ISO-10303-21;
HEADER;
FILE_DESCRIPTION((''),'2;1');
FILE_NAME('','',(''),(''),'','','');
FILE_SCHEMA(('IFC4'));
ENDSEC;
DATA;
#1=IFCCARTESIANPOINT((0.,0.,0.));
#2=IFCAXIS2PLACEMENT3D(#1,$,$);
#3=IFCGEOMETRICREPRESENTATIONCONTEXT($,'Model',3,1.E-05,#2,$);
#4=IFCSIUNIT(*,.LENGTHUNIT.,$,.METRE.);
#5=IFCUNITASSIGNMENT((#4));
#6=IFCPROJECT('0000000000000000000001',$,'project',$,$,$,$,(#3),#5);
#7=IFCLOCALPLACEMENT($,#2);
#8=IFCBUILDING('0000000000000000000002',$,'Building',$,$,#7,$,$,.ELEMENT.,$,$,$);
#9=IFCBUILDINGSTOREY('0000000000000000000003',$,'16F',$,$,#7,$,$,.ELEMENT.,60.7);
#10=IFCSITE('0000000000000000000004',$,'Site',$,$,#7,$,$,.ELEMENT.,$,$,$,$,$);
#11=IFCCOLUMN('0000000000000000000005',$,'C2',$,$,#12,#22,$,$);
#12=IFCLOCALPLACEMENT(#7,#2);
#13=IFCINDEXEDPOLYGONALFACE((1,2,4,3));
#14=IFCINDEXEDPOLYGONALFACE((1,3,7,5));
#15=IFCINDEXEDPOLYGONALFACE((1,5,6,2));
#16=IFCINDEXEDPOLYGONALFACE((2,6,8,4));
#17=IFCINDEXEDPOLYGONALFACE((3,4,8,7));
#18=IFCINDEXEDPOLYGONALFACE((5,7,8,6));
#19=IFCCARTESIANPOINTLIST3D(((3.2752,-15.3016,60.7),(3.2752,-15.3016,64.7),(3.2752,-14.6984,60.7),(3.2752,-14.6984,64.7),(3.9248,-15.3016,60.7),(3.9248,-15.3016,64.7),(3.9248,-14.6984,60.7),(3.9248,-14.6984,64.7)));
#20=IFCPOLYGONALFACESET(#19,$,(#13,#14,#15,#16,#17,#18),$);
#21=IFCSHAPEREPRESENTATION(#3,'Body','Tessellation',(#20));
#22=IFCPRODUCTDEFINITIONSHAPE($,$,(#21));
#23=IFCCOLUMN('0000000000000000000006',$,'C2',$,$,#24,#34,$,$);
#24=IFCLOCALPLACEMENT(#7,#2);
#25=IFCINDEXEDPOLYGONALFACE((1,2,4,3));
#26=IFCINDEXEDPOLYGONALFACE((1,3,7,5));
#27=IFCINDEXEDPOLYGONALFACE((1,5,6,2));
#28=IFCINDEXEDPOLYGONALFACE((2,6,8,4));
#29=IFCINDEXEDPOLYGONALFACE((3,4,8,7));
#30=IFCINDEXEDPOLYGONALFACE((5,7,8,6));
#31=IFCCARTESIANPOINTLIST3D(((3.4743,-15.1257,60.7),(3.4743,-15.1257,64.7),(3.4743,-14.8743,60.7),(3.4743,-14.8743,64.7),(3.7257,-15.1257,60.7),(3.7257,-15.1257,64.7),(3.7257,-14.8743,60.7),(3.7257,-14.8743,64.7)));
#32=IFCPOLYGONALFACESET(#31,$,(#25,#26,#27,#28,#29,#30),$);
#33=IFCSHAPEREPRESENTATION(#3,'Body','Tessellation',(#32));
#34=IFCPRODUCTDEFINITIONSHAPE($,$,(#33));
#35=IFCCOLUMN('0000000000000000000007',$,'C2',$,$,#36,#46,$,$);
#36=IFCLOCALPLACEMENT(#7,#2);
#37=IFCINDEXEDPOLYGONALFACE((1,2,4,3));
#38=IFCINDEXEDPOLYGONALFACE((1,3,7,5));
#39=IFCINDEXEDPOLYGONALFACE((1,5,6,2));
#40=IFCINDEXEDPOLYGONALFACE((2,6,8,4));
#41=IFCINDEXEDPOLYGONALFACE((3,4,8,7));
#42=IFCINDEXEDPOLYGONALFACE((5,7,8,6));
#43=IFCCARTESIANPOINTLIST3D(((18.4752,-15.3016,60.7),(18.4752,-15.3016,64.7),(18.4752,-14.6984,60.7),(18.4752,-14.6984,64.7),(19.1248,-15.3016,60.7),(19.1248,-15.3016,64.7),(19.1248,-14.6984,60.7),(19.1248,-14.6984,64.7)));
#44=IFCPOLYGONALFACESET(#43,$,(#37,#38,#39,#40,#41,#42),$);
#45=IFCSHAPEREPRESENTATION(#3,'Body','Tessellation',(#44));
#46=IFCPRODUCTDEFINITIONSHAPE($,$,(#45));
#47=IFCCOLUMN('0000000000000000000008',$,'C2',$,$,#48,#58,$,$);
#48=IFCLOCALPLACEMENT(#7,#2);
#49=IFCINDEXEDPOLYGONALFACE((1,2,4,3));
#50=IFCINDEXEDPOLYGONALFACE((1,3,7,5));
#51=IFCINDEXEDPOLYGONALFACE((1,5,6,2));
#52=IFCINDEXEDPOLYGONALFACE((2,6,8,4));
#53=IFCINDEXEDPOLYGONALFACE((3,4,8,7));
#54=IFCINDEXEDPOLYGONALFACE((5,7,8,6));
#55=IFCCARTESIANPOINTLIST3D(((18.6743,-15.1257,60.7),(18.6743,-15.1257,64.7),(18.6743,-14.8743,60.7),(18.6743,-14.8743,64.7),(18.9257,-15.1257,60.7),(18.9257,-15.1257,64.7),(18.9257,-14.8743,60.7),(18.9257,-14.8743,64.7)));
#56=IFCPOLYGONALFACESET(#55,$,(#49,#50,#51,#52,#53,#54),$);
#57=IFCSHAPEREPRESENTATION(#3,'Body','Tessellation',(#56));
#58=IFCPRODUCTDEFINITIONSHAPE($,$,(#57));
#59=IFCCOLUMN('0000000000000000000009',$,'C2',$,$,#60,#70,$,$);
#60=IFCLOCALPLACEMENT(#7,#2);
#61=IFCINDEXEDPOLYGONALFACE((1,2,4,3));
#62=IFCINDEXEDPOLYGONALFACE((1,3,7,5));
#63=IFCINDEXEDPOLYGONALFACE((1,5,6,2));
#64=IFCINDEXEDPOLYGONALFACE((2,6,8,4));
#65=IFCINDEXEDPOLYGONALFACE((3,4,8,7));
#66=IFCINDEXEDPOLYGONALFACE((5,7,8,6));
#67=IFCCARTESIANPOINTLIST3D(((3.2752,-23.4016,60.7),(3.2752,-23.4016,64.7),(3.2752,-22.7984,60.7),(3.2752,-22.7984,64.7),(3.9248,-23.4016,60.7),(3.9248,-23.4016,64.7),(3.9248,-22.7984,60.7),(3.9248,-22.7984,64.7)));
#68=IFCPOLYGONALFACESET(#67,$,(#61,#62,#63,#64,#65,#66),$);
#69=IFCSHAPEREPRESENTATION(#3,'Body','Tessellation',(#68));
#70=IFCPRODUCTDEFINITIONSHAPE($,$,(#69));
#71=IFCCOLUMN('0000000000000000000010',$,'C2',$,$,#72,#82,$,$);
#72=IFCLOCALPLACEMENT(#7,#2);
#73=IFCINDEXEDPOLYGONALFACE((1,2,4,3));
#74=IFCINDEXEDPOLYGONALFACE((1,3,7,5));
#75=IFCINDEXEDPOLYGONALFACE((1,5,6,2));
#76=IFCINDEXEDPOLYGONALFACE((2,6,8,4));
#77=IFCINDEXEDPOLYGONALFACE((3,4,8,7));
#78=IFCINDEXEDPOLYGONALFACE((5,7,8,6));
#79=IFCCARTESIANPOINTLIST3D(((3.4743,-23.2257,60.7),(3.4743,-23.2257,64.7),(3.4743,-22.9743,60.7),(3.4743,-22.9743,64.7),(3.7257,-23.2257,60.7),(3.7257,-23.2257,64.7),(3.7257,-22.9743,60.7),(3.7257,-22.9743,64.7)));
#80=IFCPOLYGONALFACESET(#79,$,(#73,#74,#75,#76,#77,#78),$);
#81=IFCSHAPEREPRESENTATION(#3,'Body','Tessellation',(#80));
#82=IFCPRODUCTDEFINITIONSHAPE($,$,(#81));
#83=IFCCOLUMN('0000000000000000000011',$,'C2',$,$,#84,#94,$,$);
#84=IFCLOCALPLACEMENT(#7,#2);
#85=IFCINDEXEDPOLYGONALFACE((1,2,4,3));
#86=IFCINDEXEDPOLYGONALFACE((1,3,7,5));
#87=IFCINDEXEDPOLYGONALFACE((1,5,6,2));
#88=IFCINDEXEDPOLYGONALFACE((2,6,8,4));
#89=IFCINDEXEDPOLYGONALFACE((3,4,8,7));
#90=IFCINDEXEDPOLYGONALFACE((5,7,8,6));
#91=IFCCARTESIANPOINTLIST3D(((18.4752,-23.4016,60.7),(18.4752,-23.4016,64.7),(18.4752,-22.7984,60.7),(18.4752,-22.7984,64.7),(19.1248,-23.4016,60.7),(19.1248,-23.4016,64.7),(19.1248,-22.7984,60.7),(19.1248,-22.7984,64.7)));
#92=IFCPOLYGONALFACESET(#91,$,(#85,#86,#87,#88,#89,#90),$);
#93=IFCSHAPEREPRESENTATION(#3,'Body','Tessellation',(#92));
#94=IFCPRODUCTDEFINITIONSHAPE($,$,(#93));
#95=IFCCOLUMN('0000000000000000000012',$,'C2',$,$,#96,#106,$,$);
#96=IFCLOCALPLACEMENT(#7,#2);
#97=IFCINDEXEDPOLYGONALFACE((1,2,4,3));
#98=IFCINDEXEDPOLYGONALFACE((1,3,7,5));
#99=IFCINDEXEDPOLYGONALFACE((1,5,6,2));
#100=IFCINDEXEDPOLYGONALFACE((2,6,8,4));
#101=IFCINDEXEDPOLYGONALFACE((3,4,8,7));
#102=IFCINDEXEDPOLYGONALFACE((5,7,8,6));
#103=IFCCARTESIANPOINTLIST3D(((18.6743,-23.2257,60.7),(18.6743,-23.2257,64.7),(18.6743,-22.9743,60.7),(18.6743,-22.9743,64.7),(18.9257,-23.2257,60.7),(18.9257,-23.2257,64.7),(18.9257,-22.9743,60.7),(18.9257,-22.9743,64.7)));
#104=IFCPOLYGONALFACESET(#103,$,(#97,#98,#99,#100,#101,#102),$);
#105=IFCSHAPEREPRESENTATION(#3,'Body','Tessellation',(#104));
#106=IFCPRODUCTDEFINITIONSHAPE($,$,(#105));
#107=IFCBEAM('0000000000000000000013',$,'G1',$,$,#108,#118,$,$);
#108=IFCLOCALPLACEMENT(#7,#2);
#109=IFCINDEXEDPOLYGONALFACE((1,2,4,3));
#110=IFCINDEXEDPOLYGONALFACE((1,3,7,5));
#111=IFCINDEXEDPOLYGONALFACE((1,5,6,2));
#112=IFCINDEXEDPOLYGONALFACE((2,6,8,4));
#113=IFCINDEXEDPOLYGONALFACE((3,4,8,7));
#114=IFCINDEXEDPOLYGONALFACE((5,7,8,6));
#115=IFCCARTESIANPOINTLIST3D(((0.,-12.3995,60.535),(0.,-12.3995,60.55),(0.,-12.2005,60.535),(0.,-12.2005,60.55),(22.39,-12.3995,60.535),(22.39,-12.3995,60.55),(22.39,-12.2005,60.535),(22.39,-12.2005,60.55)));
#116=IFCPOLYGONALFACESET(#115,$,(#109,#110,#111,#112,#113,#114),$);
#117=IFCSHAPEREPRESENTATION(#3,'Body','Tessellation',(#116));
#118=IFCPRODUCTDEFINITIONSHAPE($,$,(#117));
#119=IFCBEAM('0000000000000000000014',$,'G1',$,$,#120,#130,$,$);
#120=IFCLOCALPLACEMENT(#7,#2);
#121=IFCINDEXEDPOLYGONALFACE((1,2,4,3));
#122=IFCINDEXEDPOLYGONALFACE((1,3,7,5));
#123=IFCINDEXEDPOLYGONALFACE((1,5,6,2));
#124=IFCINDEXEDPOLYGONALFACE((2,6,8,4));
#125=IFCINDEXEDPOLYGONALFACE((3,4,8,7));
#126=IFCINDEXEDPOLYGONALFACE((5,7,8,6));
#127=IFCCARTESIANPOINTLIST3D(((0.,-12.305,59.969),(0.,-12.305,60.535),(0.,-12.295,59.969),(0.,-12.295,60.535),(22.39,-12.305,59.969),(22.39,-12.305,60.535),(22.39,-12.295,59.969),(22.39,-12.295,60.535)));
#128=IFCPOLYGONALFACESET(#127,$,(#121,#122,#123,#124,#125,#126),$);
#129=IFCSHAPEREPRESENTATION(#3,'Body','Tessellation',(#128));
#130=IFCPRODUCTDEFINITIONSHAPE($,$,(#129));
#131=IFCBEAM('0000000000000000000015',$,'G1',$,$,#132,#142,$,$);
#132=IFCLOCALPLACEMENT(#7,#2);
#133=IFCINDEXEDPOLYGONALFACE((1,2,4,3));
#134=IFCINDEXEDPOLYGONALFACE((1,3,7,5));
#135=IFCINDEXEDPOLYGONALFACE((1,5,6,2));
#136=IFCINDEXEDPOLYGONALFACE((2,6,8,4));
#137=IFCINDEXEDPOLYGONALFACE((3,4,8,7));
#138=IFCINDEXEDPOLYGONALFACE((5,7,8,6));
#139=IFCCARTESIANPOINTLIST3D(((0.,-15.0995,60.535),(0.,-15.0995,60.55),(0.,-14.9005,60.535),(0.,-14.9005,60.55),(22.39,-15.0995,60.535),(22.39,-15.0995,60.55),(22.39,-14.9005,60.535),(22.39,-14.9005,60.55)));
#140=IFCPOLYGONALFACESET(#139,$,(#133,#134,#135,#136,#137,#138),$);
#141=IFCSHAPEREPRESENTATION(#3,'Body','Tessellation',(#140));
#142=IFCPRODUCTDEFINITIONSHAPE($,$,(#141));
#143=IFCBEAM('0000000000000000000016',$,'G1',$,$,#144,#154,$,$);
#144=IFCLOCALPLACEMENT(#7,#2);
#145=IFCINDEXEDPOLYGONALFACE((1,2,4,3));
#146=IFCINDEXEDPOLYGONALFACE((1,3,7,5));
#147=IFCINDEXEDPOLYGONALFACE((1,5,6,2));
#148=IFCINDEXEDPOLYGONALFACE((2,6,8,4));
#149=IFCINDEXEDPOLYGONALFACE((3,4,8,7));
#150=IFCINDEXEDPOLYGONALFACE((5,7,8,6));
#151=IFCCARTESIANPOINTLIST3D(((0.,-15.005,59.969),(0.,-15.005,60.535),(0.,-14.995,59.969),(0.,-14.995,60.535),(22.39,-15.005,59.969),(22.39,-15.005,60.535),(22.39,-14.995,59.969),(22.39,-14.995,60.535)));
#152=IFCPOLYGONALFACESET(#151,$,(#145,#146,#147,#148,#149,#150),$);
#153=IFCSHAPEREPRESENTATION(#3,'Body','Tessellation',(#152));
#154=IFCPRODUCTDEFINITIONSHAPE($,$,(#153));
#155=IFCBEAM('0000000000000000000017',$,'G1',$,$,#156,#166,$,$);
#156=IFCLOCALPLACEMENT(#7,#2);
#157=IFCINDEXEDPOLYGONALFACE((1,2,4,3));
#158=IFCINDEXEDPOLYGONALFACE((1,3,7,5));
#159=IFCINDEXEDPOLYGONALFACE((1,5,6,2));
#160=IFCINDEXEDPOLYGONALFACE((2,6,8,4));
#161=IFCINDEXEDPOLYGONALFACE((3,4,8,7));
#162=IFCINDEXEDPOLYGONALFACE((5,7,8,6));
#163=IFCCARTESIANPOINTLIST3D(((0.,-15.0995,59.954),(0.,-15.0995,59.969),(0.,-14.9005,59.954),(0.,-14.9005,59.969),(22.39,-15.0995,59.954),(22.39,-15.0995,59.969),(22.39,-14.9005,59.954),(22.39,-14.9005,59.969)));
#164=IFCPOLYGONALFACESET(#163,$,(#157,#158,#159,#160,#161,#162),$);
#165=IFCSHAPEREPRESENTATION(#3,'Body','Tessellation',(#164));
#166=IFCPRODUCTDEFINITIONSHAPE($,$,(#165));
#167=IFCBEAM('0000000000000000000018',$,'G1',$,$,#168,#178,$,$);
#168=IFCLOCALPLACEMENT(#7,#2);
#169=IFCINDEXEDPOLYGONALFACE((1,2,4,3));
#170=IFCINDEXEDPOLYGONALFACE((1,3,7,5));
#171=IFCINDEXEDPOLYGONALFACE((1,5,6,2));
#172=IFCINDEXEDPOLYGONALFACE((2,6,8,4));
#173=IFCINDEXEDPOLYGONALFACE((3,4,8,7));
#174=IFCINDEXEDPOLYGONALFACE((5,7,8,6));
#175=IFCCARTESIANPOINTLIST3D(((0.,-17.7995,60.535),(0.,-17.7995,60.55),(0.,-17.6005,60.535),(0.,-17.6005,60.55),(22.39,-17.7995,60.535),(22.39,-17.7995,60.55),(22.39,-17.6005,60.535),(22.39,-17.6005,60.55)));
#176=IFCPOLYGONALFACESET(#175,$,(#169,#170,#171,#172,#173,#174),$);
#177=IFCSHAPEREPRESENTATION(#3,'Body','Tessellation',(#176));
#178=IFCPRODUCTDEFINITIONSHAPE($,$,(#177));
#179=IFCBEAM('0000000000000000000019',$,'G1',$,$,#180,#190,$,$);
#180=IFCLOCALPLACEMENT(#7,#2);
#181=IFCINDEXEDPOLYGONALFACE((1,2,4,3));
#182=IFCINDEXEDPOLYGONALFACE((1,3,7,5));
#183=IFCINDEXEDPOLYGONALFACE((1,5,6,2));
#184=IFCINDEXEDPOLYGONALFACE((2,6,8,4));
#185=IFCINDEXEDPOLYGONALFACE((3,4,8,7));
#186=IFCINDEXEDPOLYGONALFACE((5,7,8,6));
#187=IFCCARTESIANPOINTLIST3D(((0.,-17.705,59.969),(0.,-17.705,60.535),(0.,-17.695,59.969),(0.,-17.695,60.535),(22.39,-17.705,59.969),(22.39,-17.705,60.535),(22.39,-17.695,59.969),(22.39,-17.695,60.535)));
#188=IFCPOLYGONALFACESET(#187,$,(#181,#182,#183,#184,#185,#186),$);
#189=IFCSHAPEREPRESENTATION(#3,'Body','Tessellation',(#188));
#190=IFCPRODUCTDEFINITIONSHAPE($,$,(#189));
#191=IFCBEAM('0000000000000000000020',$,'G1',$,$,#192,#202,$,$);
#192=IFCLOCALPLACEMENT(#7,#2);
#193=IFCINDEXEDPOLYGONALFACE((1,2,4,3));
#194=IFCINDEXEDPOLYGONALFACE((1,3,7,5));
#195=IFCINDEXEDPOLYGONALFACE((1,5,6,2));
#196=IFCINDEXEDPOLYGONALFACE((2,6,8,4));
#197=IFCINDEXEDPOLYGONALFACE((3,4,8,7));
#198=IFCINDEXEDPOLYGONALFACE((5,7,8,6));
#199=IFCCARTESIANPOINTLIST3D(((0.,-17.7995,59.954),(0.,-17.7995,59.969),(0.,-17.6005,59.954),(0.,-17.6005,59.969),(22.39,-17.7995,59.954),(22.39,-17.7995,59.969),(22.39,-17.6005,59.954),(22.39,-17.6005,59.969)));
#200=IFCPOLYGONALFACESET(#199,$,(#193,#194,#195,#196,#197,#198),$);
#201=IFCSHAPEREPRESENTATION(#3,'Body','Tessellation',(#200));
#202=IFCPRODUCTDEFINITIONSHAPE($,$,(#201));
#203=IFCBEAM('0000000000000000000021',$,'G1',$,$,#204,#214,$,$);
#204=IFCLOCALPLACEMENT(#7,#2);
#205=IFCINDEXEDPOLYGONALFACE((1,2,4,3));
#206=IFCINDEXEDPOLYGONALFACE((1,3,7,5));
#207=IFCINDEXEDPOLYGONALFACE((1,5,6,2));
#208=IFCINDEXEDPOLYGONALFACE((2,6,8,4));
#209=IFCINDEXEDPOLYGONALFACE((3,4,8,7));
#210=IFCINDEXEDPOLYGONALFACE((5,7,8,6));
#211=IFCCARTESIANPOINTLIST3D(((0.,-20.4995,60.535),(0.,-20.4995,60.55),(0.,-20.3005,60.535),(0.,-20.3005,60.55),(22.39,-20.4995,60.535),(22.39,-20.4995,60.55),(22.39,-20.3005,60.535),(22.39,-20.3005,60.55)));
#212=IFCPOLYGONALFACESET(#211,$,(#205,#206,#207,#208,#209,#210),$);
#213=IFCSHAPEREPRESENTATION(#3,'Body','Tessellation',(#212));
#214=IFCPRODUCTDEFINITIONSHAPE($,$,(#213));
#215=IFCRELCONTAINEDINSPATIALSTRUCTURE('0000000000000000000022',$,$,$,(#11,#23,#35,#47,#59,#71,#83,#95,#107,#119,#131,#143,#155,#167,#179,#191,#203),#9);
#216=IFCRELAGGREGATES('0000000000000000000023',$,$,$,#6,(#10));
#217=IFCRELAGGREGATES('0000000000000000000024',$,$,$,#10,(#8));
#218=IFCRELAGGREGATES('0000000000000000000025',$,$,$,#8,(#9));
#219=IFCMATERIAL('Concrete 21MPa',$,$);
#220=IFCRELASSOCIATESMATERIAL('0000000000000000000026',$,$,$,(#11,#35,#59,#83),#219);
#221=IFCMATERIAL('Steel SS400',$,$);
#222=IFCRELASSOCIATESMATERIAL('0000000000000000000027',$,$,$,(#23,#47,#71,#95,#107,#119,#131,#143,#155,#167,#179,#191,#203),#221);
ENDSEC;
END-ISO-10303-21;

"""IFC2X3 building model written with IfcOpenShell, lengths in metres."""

from ifc_helpers import new_model, si_unit, frame, origin, origin_2d, place, context, project, spatial, rectangle, extrude, material, element, save


model = new_model("IFC2X3")

# Units and contexts
model_context = context("Model", 3, precision=1e-05, world=origin())
ifc_project = project(units=[si_unit("LENGTHUNIT", "METRE")], contexts=[model_context])

# Site, building, storey
placement = place(None, origin())
site = spatial("IfcSite", under=ifc_project, at=placement, Name="Site", CompositionType="ELEMENT")
building = spatial("IfcBuilding", under=site, at=placement, Name="Building", CompositionType="ELEMENT")
storey = spatial("IfcBuildingStorey", under=building, at=placement, Name="16F", CompositionType="ELEMENT", Elevation=60.7)

# Columns
ifc_material_1 = material(Name="Concrete 21MPa")
column_1_placement = place(None, frame((3.6, -15.0, 60.7)))
element("IfcColumn", 1, at=column_1_placement, inside=storey, material=ifc_material_1, Name="C2", context=model_context, shape_type="SweptSolid", body=[
    extrude(rectangle(XDim=0.6496, YDim=0.6032, at=origin_2d()), origin(), (0.0, 0.0, 1.0), 4.0),
])
ifc_material_2 = material(Name="Steel SS400")
column_2_placement = place(None, frame((3.6, -15.0, 60.7)))
element("IfcColumn", 2, at=column_2_placement, inside=storey, material=ifc_material_2, Name="C2", context=model_context, shape_type="SweptSolid", body=[
    extrude(rectangle(XDim=0.2513, YDim=0.2513, at=origin_2d()), origin(), (0.0, 0.0, 1.0), 4.0),
])
column_3_placement = place(None, frame((18.8, -15.0, 60.7)))
element("IfcColumn", 3, at=column_3_placement, inside=storey, material=ifc_material_1, Name="C2", context=model_context, shape_type="SweptSolid", body=[
    extrude(rectangle(XDim=0.6496, YDim=0.6032, at=origin_2d()), origin(), (0.0, 0.0, 1.0), 4.0),
])
column_4_placement = place(None, frame((18.8, -15.0, 60.7)))
element("IfcColumn", 4, at=column_4_placement, inside=storey, material=ifc_material_2, Name="C2", context=model_context, shape_type="SweptSolid", body=[
    extrude(rectangle(XDim=0.2513, YDim=0.2513, at=origin_2d()), origin(), (0.0, 0.0, 1.0), 4.0),
])
column_5_placement = place(None, frame((3.6, -23.1, 60.7)))
element("IfcColumn", 5, at=column_5_placement, inside=storey, material=ifc_material_1, Name="C2", context=model_context, shape_type="SweptSolid", body=[
    extrude(rectangle(XDim=0.6496, YDim=0.6032, at=origin_2d()), origin(), (0.0, 0.0, 1.0), 4.0),
])
column_6_placement = place(None, frame((3.6, -23.1, 60.7)))
element("IfcColumn", 6, at=column_6_placement, inside=storey, material=ifc_material_2, Name="C2", context=model_context, shape_type="SweptSolid", body=[
    extrude(rectangle(XDim=0.2513, YDim=0.2513, at=origin_2d()), origin(), (0.0, 0.0, 1.0), 4.0),
])
column_7_placement = place(None, frame((18.8, -23.1, 60.7)))
element("IfcColumn", 7, at=column_7_placement, inside=storey, material=ifc_material_1, Name="C2", context=model_context, shape_type="SweptSolid", body=[
    extrude(rectangle(XDim=0.6496, YDim=0.6032, at=origin_2d()), origin(), (0.0, 0.0, 1.0), 4.0),
])
column_8_placement = place(None, frame((18.8, -23.1, 60.7)))
element("IfcColumn", 8, at=column_8_placement, inside=storey, material=ifc_material_2, Name="C2", context=model_context, shape_type="SweptSolid", body=[
    extrude(rectangle(XDim=0.2513, YDim=0.2513, at=origin_2d()), origin(), (0.0, 0.0, 1.0), 4.0),
])

# Beams
beam_1_placement = place(None, frame((11.195, -12.3, 60.535)))
element("IfcBeam", 9, at=beam_1_placement, inside=storey, material=ifc_material_2, Name="G1", context=model_context, shape_type="SweptSolid", body=[
    extrude(rectangle(XDim=22.39, YDim=0.199, at=origin_2d()), origin(), (0.0, 0.0, 1.0), 0.015),
])
beam_2_placement = place(None, frame((11.195, -12.3, 59.969)))
element("IfcBeam", 10, at=beam_2_placement, inside=storey, material=ifc_material_2, Name="G1", context=model_context, shape_type="SweptSolid", body=[
    extrude(rectangle(XDim=22.39, YDim=0.01, at=origin_2d()), origin(), (0.0, 0.0, 1.0), 0.566),
])
beam_3_placement = place(None, frame((11.195, -15.0, 60.535)))
element("IfcBeam", 11, at=beam_3_placement, inside=storey, material=ifc_material_2, Name="G1", context=model_context, shape_type="SweptSolid", body=[
    extrude(rectangle(XDim=22.39, YDim=0.199, at=origin_2d()), origin(), (0.0, 0.0, 1.0), 0.015),
])
beam_4_placement = place(None, frame((11.195, -15.0, 59.969)))
element("IfcBeam", 12, at=beam_4_placement, inside=storey, material=ifc_material_2, Name="G1", context=model_context, shape_type="SweptSolid", body=[
    extrude(rectangle(XDim=22.39, YDim=0.01, at=origin_2d()), origin(), (0.0, 0.0, 1.0), 0.566),
])
for number, where, name in (
    (13, (11.195, -15.0, 59.954), "G1"),
    (14, (11.195, -17.7, 60.535), "G1"),
):
    element("IfcBeam", number, at=place(None, frame(where)), inside=storey, material=ifc_material_2, Name=name, context=model_context, shape_type="SweptSolid", body=[
        extrude(rectangle(XDim=22.39, YDim=0.199, at=origin_2d()), origin(), (0.0, 0.0, 1.0), 0.015),
    ])
beam_5_placement = place(None, frame((11.195, -17.7, 59.969)))
element("IfcBeam", 15, at=beam_5_placement, inside=storey, material=ifc_material_2, Name="G1", context=model_context, shape_type="SweptSolid", body=[
    extrude(rectangle(XDim=22.39, YDim=0.01, at=origin_2d()), origin(), (0.0, 0.0, 1.0), 0.566),
])
for number, where, name in (
    (16, (11.195, -17.7, 59.954), "G1"),
    (17, (11.195, -20.4, 60.535), "G1"),
):
    element("IfcBeam", number, at=place(None, frame(where)), inside=storey, material=ifc_material_2, Name=name, context=model_context, shape_type="SweptSolid", body=[
        extrude(rectangle(XDim=22.39, YDim=0.199, at=origin_2d()), origin(), (0.0, 0.0, 1.0), 0.015),
    ])

save(model, "model.ifc")
